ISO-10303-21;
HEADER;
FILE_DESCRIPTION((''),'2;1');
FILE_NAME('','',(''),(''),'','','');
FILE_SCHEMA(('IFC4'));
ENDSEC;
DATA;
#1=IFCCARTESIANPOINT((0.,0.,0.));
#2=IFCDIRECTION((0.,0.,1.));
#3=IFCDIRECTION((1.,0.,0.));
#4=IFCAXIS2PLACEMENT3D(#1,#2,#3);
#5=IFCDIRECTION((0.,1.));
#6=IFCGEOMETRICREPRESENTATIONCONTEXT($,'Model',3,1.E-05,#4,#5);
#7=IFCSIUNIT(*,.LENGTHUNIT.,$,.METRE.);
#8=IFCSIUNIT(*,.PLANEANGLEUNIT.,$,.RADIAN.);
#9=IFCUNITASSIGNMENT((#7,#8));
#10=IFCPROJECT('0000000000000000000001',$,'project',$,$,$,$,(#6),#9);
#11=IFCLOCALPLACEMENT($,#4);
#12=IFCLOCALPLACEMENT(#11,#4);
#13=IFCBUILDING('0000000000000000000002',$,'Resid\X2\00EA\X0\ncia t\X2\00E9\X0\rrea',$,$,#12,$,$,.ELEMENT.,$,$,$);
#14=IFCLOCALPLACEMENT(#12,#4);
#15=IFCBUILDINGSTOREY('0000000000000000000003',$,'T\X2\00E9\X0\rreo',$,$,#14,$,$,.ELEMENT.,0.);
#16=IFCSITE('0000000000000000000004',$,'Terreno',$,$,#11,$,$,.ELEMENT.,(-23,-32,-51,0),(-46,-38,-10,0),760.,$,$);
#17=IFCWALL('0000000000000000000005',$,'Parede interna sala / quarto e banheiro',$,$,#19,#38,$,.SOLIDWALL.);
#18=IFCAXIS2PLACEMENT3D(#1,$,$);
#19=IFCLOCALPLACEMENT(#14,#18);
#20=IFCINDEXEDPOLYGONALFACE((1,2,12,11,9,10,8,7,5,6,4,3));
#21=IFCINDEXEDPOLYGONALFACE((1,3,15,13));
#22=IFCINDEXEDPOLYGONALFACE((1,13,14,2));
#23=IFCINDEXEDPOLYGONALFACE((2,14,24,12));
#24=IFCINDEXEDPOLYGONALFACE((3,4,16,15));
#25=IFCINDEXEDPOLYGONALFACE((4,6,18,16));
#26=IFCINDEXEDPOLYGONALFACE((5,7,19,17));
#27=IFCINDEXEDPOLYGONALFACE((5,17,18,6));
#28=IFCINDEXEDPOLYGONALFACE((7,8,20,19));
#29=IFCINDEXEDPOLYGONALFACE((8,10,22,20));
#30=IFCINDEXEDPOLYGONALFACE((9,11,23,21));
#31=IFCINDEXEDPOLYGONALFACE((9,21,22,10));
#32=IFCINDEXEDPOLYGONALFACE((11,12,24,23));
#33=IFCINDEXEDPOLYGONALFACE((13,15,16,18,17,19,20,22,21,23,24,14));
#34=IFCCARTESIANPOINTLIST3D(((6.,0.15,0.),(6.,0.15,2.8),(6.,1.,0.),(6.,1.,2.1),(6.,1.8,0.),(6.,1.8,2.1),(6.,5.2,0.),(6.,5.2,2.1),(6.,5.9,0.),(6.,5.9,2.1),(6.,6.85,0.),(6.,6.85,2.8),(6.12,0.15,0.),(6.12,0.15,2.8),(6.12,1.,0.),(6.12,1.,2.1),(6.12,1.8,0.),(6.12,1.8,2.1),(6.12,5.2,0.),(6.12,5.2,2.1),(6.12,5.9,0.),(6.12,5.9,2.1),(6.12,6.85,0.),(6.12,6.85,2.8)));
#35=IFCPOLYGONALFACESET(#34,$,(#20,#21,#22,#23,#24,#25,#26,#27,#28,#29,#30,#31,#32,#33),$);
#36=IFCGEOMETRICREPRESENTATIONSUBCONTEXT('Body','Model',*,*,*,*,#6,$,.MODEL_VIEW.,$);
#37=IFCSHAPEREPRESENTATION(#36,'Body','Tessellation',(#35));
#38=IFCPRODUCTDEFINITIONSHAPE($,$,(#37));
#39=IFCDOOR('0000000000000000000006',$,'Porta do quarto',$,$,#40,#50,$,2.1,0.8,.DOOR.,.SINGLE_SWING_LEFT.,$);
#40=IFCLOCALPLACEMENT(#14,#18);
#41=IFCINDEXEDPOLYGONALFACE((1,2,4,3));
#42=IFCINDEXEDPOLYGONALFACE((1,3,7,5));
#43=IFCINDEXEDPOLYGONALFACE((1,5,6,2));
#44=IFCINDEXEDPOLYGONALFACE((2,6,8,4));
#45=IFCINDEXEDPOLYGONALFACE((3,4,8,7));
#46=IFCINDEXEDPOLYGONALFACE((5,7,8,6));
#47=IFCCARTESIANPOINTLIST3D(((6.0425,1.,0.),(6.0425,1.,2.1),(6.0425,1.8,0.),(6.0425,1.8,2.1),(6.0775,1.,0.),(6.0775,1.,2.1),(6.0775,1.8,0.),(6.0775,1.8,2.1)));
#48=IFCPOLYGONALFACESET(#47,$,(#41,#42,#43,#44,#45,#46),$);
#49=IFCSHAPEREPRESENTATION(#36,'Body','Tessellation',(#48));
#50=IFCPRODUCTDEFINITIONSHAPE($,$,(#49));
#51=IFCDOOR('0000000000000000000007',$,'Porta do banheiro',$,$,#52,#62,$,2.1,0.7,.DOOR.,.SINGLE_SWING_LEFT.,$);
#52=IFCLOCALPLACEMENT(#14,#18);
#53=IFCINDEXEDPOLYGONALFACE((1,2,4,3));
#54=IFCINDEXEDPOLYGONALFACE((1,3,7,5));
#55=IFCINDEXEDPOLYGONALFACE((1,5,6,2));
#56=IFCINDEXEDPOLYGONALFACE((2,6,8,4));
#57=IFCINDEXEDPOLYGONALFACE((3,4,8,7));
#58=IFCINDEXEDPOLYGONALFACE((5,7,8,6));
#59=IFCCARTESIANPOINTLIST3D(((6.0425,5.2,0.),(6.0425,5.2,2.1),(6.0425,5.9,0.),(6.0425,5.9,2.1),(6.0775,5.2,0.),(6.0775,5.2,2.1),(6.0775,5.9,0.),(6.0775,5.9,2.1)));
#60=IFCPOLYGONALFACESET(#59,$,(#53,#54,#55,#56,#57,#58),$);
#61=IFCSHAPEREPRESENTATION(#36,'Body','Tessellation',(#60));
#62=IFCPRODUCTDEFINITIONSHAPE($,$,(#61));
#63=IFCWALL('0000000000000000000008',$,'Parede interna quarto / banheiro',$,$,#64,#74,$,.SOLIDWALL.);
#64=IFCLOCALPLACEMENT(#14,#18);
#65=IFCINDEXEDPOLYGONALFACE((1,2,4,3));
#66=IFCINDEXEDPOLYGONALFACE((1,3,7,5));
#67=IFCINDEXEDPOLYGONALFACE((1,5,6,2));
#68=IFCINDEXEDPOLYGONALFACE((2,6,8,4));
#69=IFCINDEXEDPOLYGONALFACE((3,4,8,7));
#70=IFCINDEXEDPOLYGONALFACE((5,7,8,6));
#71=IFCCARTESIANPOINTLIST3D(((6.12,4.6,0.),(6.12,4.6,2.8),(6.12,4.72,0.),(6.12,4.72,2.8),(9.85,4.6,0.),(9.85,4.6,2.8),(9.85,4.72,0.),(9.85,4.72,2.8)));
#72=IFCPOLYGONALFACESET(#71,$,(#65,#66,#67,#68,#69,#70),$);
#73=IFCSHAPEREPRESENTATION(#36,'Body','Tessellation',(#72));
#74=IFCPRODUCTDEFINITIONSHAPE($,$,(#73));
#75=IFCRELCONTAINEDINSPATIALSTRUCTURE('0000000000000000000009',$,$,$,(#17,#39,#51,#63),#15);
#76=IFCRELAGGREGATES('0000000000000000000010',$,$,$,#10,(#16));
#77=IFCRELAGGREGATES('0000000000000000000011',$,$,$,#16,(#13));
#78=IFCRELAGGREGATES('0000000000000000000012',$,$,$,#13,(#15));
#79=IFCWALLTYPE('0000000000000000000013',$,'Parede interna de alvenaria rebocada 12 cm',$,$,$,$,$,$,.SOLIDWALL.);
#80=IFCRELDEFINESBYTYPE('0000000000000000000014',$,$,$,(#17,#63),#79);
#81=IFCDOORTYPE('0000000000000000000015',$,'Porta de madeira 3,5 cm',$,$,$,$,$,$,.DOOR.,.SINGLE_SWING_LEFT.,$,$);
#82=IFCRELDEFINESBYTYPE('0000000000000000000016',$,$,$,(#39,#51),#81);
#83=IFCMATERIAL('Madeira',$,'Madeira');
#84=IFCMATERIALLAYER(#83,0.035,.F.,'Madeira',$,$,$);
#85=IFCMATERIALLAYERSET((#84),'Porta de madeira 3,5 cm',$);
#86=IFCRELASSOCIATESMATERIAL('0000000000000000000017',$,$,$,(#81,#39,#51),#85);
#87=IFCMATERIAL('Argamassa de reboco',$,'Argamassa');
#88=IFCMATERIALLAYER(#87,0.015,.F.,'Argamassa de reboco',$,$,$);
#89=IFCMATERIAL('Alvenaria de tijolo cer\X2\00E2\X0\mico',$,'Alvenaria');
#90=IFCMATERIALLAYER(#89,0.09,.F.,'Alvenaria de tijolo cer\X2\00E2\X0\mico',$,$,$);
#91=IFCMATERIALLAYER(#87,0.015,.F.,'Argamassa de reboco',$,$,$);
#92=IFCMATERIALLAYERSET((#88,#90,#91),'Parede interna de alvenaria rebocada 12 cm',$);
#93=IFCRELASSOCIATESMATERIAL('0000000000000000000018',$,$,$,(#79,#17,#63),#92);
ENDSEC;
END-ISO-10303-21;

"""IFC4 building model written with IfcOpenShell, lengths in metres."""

from ifc_helpers import new_model, si_unit, direction, frame, frame_2d, origin_with_axes, place, context, subcontext, project, spatial, rectangle, extrude, material, layer, layer_set, layer_usage, type_object, element, fill, save


model = new_model("IFC4")

# Units and contexts
model_context = context("Model", 3, precision=1e-05, world=origin_with_axes(), true_north=direction((0.0, 1.0)))
body_context = subcontext(model_context, "Body", "Model", "MODEL_VIEW")
ifc_project = project(units=[si_unit("LENGTHUNIT", "METRE"), si_unit("PLANEANGLEUNIT", "RADIAN")], contexts=[model_context])

# Site, building, storey
site_placement = place(None, origin_with_axes())
site = spatial("IfcSite", under=ifc_project, at=site_placement, Name="Terreno", CompositionType="ELEMENT", RefLatitude=(-23, -32, -51, 0), RefLongitude=(-46, -38, -10, 0), RefElevation=760.0)
building_placement = place(site_placement, origin_with_axes())
building = spatial("IfcBuilding", under=site, at=building_placement, Name="Residência térrea", CompositionType="ELEMENT")
storey_placement = place(building_placement, origin_with_axes())
storey = spatial("IfcBuildingStorey", under=building, at=storey_placement, Name="Térreo", CompositionType="ELEMENT", Elevation=0.0)

# Shared definitions
ifc_material_1 = material(Name="Argamassa de reboco", Category="Argamassa")

# Shared definitions
ifc_material_2 = material(Name="Alvenaria de tijolo cerâmico", Category="Alvenaria")
ifc_material_3 = material(Name="Madeira", Category="Madeira")
ifc_layer_1 = layer(ifc_material_3, 0.035, ventilated=False, Name="Madeira")
ifc_layer_set_1 = layer_set([ifc_layer_1], Name="Porta de madeira 3,5 cm")
door_type = type_object("IfcDoorType", Name="Porta de madeira 3,5 cm", OperationType="SINGLE_SWING_LEFT", PredefinedType="DOOR", material=ifc_layer_set_1)

# Wall, openings, doors
ifc_layer_2 = layer(ifc_material_1, 0.015, ventilated=False, Name="Argamassa de reboco")
ifc_layer_3 = layer(ifc_material_2, 0.09, ventilated=False, Name="Alvenaria de tijolo cerâmico")
ifc_layer_4 = layer(ifc_material_1, 0.015, ventilated=False, Name="Argamassa de reboco")
ifc_layer_set_2 = layer_set([ifc_layer_2, ifc_layer_3, ifc_layer_4], Name="Parede interna de alvenaria rebocada 12 cm")
ifc_layer_usage_1 = layer_usage(ifc_layer_set_2, "AXIS2", "POSITIVE", 0.0)
wall_type_1 = type_object("IfcWallType", Name="Parede interna de alvenaria rebocada 12 cm", PredefinedType="SOLIDWALL", material=ifc_layer_set_2)
wall_1_placement = place(storey_placement, frame((6.12, 0.15, 0.0), z_axis=(0.0, 0.0, 1.0), x_axis=(0.0, 1.0, 0.0)))
wall_1 = element("IfcWall", 1, at=wall_1_placement, inside=storey, type_object=wall_type_1, material=ifc_layer_usage_1, Name="Parede interna sala / quarto e banheiro", PredefinedType="SOLIDWALL", context=body_context, shape_type="SweptSolid", body=[
    extrude(rectangle(XDim=6.7, YDim=0.12, at=frame_2d((3.35, 0.06))), origin_with_axes(), (0.0, 0.0, 1.0), 2.8),
])
opening_1_placement = place(wall_1_placement, frame((0.85, 0.0, 0.0), z_axis=(0.0, 0.0, 1.0), x_axis=(1.0, 0.0, 0.0)))
opening_1 = element("IfcOpeningElement", 2, at=opening_1_placement, cuts=wall_1, PredefinedType="OPENING", context=body_context, shape_type="SweptSolid", body=[
    extrude(rectangle(XDim=0.8, YDim=0.22, at=frame_2d((0.4, 0.06))), origin_with_axes(), (0.0, 0.0, 1.0), 2.1),
])
opening_2_placement = place(wall_1_placement, frame((5.05, 0.0, 0.0), z_axis=(0.0, 0.0, 1.0), x_axis=(1.0, 0.0, 0.0)))
opening_2 = element("IfcOpeningElement", 3, at=opening_2_placement, cuts=wall_1, PredefinedType="OPENING", context=body_context, shape_type="SweptSolid", body=[
    extrude(rectangle(XDim=0.7, YDim=0.22, at=frame_2d((0.35, 0.06))), origin_with_axes(), (0.0, 0.0, 1.0), 2.1),
])
door_1_placement = place(opening_1_placement, origin_with_axes())
door_1 = element("IfcDoor", 4, at=door_1_placement, inside=storey, type_object=door_type, material=ifc_layer_set_1, Name="Porta do quarto", OperationType="SINGLE_SWING_LEFT", OverallHeight=2.1, OverallWidth=0.8, PredefinedType="DOOR", context=body_context, shape_type="SweptSolid", body=[
    extrude(rectangle(XDim=0.8, YDim=0.035, at=frame_2d((0.4, 0.06))), origin_with_axes(), (0.0, 0.0, 1.0), 2.1),
])
fill(opening_1, door_1)
door_2_placement = place(opening_2_placement, origin_with_axes())
door_2 = element("IfcDoor", 5, at=door_2_placement, inside=storey, type_object=door_type, material=ifc_layer_set_1, Name="Porta do banheiro", OperationType="SINGLE_SWING_LEFT", OverallHeight=2.1, OverallWidth=0.7, PredefinedType="DOOR", context=body_context, shape_type="SweptSolid", body=[
    extrude(rectangle(XDim=0.7, YDim=0.035, at=frame_2d((0.35, 0.06))), origin_with_axes(), (0.0, 0.0, 1.0), 2.1),
])
fill(opening_2, door_2)

# Wall
ifc_layer_usage_2 = layer_usage(ifc_layer_set_2, "AXIS2", "POSITIVE", 0.0)
wall_2_placement = place(storey_placement, frame((6.12, 4.6, 0.0), z_axis=(0.0, 0.0, 1.0), x_axis=(1.0, 0.0, 0.0)))
element("IfcWall", 6, at=wall_2_placement, inside=storey, type_object=wall_type_1, material=ifc_layer_usage_2, Name="Parede interna quarto / banheiro", PredefinedType="SOLIDWALL", context=body_context, shape_type="SweptSolid", body=[
    extrude(rectangle(XDim=3.73, YDim=0.12, at=frame_2d((1.865, 0.06))), origin_with_axes(), (0.0, 0.0, 1.0), 2.8),
])

save(model, "model.ifc")
